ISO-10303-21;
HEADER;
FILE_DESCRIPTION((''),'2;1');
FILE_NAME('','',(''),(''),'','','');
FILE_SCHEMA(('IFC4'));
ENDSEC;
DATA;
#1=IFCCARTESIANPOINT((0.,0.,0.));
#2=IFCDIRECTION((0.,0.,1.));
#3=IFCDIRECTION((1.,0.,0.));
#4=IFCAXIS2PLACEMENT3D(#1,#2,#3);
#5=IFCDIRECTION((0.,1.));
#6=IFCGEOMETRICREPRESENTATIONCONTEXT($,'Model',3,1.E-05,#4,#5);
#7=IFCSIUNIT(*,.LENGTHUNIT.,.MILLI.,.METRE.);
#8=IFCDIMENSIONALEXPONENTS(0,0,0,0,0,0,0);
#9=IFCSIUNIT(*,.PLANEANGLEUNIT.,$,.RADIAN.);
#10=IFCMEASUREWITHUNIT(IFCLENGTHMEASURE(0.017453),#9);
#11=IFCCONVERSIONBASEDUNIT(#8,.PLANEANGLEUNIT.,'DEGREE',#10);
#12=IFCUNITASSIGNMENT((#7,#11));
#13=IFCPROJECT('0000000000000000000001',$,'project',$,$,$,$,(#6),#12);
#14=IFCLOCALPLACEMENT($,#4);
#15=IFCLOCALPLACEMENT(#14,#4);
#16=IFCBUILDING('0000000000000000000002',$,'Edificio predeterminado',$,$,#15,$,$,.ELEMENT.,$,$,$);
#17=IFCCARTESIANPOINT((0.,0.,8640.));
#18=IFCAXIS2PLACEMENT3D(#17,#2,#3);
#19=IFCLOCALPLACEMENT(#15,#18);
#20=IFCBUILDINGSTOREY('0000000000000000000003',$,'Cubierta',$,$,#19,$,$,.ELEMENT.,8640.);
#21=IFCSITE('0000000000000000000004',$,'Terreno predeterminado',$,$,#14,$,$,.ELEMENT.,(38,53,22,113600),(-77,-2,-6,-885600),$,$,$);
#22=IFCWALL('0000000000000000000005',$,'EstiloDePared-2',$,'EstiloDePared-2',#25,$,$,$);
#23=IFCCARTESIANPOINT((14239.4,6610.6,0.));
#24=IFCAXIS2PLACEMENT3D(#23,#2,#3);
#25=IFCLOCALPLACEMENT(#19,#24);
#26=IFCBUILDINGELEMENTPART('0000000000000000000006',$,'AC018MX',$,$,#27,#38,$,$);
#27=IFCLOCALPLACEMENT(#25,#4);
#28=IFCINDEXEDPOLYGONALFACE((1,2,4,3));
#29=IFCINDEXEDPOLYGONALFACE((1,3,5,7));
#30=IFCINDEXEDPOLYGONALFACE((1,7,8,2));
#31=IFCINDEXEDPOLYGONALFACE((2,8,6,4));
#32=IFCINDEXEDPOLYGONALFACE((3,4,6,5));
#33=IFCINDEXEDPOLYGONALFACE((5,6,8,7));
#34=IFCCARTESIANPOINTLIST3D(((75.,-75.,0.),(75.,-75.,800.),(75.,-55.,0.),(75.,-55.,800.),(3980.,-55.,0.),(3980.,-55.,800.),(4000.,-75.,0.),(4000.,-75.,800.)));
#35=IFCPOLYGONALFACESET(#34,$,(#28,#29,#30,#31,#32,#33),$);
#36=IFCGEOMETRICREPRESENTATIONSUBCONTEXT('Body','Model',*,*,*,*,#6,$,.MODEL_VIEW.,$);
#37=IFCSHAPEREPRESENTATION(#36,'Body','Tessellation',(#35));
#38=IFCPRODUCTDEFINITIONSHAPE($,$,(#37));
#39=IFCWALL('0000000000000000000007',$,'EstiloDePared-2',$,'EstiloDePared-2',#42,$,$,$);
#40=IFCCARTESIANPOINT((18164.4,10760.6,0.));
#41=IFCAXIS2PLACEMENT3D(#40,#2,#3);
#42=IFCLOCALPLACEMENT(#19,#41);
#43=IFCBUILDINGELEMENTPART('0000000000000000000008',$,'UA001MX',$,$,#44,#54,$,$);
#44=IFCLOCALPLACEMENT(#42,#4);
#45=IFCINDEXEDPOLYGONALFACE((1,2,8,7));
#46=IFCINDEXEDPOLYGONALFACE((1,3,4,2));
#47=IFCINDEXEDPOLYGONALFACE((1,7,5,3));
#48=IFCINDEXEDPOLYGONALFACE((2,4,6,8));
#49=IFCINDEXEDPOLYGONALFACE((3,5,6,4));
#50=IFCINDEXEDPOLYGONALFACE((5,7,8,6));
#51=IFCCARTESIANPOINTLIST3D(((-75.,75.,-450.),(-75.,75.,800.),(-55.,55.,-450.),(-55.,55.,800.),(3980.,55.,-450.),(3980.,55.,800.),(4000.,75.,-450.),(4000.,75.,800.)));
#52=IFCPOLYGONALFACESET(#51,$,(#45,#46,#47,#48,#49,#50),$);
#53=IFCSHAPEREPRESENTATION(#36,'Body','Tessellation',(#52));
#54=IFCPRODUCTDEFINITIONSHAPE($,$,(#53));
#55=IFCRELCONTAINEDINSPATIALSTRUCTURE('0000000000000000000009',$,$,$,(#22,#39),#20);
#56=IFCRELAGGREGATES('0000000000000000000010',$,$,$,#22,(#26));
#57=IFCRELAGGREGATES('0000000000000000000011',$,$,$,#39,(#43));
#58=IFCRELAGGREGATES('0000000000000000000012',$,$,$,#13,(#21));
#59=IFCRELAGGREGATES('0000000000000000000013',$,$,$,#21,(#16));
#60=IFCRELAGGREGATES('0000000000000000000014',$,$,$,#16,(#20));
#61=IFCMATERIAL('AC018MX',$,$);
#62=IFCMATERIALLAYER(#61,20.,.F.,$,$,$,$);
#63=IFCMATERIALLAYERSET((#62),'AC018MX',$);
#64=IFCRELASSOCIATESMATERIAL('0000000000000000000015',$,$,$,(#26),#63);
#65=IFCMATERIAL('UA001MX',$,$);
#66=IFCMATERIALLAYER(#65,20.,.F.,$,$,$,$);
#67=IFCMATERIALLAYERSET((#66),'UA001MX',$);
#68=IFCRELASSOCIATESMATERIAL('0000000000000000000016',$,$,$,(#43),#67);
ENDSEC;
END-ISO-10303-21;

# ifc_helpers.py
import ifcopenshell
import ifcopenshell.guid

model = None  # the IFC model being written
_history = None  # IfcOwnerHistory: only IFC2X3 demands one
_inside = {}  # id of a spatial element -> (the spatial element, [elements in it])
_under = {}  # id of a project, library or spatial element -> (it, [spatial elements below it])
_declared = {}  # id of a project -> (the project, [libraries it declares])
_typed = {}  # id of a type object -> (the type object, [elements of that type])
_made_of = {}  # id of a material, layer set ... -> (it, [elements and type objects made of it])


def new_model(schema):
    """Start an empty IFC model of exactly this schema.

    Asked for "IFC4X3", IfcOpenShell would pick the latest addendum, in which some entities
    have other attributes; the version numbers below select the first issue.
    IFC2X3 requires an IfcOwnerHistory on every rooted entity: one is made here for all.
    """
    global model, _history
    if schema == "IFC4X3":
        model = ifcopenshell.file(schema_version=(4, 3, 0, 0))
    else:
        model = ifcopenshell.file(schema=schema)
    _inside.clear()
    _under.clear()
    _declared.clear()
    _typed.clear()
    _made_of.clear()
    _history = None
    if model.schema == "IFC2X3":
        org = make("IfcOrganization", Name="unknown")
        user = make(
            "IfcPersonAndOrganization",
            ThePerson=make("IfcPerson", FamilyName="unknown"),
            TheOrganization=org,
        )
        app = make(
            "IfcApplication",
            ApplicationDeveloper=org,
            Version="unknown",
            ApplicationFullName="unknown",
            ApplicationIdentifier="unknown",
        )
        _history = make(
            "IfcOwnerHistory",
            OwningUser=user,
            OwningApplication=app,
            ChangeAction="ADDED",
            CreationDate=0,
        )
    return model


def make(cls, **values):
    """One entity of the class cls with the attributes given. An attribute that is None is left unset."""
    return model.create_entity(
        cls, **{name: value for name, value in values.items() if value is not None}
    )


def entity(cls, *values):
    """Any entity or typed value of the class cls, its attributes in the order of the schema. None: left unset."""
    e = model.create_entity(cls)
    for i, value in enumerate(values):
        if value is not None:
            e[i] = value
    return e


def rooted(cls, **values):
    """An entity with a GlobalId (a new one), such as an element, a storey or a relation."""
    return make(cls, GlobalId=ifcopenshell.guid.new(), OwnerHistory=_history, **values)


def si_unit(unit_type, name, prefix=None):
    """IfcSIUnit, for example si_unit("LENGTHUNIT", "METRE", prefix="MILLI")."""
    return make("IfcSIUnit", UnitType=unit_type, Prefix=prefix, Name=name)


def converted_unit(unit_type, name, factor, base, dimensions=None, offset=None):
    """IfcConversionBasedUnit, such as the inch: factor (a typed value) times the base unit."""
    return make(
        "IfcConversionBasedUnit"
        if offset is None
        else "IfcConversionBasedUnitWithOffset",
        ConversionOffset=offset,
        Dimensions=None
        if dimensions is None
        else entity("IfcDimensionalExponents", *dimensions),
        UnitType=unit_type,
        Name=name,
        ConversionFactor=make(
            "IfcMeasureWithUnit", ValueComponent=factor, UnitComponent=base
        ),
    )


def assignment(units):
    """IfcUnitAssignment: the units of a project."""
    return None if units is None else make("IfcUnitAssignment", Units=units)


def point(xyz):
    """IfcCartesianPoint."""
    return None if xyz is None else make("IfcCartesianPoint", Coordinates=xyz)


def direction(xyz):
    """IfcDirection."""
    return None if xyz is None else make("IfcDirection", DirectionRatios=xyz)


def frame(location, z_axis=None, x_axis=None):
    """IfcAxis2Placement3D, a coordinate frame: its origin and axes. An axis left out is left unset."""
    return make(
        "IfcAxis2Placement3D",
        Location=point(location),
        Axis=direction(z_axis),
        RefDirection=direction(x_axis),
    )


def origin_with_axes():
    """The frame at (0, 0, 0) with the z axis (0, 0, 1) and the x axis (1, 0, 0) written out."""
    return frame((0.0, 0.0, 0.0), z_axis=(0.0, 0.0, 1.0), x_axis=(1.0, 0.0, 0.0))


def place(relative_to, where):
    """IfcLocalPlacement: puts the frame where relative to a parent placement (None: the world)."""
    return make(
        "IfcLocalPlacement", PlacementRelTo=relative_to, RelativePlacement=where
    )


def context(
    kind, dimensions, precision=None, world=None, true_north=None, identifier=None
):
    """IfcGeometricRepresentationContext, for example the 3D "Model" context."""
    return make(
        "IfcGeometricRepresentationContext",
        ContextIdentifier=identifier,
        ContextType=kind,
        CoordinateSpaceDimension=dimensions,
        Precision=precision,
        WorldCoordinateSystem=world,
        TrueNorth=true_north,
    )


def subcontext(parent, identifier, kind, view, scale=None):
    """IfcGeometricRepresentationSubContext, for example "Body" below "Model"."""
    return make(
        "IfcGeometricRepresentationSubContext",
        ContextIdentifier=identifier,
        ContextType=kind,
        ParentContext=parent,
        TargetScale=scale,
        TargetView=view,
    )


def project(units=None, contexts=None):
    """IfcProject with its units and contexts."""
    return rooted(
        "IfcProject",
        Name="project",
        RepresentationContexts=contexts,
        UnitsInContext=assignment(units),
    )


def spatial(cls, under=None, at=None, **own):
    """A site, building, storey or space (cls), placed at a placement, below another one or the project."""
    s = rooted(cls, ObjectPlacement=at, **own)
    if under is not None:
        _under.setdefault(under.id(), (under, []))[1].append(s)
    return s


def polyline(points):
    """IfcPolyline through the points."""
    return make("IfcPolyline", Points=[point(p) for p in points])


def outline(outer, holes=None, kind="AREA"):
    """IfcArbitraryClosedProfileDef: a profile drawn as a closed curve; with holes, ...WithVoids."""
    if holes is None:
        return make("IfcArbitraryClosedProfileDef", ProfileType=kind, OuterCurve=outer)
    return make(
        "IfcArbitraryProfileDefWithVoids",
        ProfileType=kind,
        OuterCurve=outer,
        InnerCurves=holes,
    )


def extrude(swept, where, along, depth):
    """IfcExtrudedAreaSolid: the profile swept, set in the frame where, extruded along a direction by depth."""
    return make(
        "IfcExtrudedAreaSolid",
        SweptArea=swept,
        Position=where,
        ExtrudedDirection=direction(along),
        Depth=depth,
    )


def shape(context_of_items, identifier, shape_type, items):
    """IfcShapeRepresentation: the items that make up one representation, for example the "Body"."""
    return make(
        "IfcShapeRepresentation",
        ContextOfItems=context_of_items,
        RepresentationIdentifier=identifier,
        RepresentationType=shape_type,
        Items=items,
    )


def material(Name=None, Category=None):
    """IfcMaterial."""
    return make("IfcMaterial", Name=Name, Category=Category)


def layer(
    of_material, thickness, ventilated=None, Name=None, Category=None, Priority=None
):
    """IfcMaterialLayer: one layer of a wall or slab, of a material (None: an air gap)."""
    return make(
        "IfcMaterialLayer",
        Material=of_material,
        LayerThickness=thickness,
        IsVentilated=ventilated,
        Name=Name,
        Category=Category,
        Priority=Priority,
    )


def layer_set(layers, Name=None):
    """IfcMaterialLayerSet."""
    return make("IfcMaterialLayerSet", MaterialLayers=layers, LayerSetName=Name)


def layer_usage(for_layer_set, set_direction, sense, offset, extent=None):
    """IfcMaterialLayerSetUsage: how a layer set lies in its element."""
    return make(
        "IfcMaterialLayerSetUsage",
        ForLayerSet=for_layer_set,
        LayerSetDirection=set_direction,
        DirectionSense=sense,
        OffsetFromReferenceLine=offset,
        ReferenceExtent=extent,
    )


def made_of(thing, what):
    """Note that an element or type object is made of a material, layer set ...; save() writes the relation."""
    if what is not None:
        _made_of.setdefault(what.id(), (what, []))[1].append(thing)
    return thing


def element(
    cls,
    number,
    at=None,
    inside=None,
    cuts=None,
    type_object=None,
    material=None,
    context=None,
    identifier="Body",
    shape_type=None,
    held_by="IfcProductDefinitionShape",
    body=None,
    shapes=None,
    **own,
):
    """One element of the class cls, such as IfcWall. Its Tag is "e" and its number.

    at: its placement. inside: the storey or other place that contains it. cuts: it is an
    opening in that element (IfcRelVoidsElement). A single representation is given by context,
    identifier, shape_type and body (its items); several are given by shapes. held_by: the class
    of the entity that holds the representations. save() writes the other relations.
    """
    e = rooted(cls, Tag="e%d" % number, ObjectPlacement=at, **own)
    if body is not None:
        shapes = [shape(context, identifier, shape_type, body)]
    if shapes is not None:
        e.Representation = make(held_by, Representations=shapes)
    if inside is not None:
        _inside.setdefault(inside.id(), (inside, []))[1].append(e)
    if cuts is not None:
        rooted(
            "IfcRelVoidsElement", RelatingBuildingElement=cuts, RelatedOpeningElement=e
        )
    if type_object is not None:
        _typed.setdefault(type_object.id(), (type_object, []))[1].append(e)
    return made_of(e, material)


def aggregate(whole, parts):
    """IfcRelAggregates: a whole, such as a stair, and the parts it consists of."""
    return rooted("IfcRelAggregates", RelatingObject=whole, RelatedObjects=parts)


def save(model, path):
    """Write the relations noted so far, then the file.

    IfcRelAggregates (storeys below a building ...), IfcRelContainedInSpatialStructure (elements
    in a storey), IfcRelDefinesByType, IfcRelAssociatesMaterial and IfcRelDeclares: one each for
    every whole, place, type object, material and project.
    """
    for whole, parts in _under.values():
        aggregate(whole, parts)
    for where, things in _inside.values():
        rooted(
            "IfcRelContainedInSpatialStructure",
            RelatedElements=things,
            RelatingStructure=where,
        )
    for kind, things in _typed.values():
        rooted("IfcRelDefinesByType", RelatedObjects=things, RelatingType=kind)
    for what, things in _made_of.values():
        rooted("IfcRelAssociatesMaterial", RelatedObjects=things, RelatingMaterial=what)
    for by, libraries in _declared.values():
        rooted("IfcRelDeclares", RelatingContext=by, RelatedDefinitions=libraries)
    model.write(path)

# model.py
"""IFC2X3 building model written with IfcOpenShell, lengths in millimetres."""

from ifc_helpers import new_model, entity, si_unit, converted_unit, direction, frame, origin_with_axes, place, context, subcontext, project, spatial, polyline, outline, extrude, material, layer, layer_set, layer_usage, element, aggregate, save


model = new_model("IFC2X3")

# Units and contexts
model_context = context("Model", 3, precision=1e-05, world=origin_with_axes(), true_north=direction((0.0, 1.0)))
body_context = subcontext(model_context, "Body", "Model", "MODEL_VIEW")
ifc_project = project(units=[si_unit("LENGTHUNIT", "METRE", prefix="MILLI"), converted_unit("PLANEANGLEUNIT", "DEGREE", entity("IfcLengthMeasure", 0.017453), si_unit("PLANEANGLEUNIT", "RADIAN"), dimensions=[0, 0, 0, 0, 0, 0, 0])], contexts=[model_context])

# Site, building, storey
site_placement = place(None, origin_with_axes())
site = spatial("IfcSite", under=ifc_project, at=site_placement, Name="Terreno predeterminado", CompositionType="ELEMENT", RefLatitude=(38, 53, 22, 113600), RefLongitude=(-77, -2, -6, -885600))
building_placement = place(site_placement, origin_with_axes())
building = spatial("IfcBuilding", under=site, at=building_placement, Name="Edificio predeterminado", CompositionType="ELEMENT")
storey_placement = place(building_placement, frame((0.0, 0.0, 8640.0), z_axis=(0.0, 0.0, 1.0), x_axis=(1.0, 0.0, 0.0)))
storey = spatial("IfcBuildingStorey", under=building, at=storey_placement, Name="Cubierta", CompositionType="ELEMENT", Elevation=8640.0)

# Walls, building element parts
wall_1_placement = place(storey_placement, frame((14239.4, 6610.6, 0.0), z_axis=(0.0, 0.0, 1.0), x_axis=(1.0, 0.0, 0.0)))
wall_1 = element("IfcWall", 1, at=wall_1_placement, inside=storey, Name="EstiloDePared-2", ObjectType="EstiloDePared-2")
ifc_material_1 = material(Name="AC018MX")
ifc_layer_1 = layer(ifc_material_1, 20.0, ventilated=False)
ifc_layer_set_1 = layer_set([ifc_layer_1], Name="AC018MX")
ifc_layer_usage_1 = layer_usage(ifc_layer_set_1, "AXIS2", "NEGATIVE", 55.0)
building_element_part_1_placement = place(wall_1_placement, origin_with_axes())
building_element_part_1 = element("IfcBuildingElementPart", 2, at=building_element_part_1_placement, material=ifc_layer_usage_1, Name="AC018MX", context=body_context, shape_type="SweptSolid", body=[
    extrude(outline(polyline([(3980.0, -55.0), (4000.0, -75.0), (75.0, -75.0), (75.0, -55.0), (3980.0, -55.0)])), origin_with_axes(), (0.0, 0.0, 1.0), 800.0),
])
aggregate(wall_1, [building_element_part_1])
wall_2_placement = place(storey_placement, frame((18164.4, 10760.6, 0.0), z_axis=(0.0, 0.0, 1.0), x_axis=(1.0, 0.0, 0.0)))
wall_2 = element("IfcWall", 3, at=wall_2_placement, inside=storey, Name="EstiloDePared-2", ObjectType="EstiloDePared-2")
ifc_material_2 = material(Name="UA001MX")
ifc_layer_2 = layer(ifc_material_2, 20.0, ventilated=False)
ifc_layer_set_2 = layer_set([ifc_layer_2], Name="UA001MX")
ifc_layer_usage_2 = layer_usage(ifc_layer_set_2, "AXIS2", "NEGATIVE", -75.0)
building_element_part_2_placement = place(wall_2_placement, origin_with_axes())
building_element_part_2 = element("IfcBuildingElementPart", 4, at=building_element_part_2_placement, material=ifc_layer_usage_2, Name="UA001MX", context=body_context, shape_type="SweptSolid", body=[
    extrude(outline(polyline([(4000.0, 75.0), (3980.0, 55.0), (-55.0, 55.0), (-75.0, 75.0), (4000.0, 75.0)])), frame((0.0, 0.0, -450.0), z_axis=(0.0, 0.0, 1.0), x_axis=(1.0, 0.0, 0.0)), (0.0, 0.0, 1.0), 1250.0),
])
aggregate(wall_2, [building_element_part_2])

save(model, "model.ifc")
